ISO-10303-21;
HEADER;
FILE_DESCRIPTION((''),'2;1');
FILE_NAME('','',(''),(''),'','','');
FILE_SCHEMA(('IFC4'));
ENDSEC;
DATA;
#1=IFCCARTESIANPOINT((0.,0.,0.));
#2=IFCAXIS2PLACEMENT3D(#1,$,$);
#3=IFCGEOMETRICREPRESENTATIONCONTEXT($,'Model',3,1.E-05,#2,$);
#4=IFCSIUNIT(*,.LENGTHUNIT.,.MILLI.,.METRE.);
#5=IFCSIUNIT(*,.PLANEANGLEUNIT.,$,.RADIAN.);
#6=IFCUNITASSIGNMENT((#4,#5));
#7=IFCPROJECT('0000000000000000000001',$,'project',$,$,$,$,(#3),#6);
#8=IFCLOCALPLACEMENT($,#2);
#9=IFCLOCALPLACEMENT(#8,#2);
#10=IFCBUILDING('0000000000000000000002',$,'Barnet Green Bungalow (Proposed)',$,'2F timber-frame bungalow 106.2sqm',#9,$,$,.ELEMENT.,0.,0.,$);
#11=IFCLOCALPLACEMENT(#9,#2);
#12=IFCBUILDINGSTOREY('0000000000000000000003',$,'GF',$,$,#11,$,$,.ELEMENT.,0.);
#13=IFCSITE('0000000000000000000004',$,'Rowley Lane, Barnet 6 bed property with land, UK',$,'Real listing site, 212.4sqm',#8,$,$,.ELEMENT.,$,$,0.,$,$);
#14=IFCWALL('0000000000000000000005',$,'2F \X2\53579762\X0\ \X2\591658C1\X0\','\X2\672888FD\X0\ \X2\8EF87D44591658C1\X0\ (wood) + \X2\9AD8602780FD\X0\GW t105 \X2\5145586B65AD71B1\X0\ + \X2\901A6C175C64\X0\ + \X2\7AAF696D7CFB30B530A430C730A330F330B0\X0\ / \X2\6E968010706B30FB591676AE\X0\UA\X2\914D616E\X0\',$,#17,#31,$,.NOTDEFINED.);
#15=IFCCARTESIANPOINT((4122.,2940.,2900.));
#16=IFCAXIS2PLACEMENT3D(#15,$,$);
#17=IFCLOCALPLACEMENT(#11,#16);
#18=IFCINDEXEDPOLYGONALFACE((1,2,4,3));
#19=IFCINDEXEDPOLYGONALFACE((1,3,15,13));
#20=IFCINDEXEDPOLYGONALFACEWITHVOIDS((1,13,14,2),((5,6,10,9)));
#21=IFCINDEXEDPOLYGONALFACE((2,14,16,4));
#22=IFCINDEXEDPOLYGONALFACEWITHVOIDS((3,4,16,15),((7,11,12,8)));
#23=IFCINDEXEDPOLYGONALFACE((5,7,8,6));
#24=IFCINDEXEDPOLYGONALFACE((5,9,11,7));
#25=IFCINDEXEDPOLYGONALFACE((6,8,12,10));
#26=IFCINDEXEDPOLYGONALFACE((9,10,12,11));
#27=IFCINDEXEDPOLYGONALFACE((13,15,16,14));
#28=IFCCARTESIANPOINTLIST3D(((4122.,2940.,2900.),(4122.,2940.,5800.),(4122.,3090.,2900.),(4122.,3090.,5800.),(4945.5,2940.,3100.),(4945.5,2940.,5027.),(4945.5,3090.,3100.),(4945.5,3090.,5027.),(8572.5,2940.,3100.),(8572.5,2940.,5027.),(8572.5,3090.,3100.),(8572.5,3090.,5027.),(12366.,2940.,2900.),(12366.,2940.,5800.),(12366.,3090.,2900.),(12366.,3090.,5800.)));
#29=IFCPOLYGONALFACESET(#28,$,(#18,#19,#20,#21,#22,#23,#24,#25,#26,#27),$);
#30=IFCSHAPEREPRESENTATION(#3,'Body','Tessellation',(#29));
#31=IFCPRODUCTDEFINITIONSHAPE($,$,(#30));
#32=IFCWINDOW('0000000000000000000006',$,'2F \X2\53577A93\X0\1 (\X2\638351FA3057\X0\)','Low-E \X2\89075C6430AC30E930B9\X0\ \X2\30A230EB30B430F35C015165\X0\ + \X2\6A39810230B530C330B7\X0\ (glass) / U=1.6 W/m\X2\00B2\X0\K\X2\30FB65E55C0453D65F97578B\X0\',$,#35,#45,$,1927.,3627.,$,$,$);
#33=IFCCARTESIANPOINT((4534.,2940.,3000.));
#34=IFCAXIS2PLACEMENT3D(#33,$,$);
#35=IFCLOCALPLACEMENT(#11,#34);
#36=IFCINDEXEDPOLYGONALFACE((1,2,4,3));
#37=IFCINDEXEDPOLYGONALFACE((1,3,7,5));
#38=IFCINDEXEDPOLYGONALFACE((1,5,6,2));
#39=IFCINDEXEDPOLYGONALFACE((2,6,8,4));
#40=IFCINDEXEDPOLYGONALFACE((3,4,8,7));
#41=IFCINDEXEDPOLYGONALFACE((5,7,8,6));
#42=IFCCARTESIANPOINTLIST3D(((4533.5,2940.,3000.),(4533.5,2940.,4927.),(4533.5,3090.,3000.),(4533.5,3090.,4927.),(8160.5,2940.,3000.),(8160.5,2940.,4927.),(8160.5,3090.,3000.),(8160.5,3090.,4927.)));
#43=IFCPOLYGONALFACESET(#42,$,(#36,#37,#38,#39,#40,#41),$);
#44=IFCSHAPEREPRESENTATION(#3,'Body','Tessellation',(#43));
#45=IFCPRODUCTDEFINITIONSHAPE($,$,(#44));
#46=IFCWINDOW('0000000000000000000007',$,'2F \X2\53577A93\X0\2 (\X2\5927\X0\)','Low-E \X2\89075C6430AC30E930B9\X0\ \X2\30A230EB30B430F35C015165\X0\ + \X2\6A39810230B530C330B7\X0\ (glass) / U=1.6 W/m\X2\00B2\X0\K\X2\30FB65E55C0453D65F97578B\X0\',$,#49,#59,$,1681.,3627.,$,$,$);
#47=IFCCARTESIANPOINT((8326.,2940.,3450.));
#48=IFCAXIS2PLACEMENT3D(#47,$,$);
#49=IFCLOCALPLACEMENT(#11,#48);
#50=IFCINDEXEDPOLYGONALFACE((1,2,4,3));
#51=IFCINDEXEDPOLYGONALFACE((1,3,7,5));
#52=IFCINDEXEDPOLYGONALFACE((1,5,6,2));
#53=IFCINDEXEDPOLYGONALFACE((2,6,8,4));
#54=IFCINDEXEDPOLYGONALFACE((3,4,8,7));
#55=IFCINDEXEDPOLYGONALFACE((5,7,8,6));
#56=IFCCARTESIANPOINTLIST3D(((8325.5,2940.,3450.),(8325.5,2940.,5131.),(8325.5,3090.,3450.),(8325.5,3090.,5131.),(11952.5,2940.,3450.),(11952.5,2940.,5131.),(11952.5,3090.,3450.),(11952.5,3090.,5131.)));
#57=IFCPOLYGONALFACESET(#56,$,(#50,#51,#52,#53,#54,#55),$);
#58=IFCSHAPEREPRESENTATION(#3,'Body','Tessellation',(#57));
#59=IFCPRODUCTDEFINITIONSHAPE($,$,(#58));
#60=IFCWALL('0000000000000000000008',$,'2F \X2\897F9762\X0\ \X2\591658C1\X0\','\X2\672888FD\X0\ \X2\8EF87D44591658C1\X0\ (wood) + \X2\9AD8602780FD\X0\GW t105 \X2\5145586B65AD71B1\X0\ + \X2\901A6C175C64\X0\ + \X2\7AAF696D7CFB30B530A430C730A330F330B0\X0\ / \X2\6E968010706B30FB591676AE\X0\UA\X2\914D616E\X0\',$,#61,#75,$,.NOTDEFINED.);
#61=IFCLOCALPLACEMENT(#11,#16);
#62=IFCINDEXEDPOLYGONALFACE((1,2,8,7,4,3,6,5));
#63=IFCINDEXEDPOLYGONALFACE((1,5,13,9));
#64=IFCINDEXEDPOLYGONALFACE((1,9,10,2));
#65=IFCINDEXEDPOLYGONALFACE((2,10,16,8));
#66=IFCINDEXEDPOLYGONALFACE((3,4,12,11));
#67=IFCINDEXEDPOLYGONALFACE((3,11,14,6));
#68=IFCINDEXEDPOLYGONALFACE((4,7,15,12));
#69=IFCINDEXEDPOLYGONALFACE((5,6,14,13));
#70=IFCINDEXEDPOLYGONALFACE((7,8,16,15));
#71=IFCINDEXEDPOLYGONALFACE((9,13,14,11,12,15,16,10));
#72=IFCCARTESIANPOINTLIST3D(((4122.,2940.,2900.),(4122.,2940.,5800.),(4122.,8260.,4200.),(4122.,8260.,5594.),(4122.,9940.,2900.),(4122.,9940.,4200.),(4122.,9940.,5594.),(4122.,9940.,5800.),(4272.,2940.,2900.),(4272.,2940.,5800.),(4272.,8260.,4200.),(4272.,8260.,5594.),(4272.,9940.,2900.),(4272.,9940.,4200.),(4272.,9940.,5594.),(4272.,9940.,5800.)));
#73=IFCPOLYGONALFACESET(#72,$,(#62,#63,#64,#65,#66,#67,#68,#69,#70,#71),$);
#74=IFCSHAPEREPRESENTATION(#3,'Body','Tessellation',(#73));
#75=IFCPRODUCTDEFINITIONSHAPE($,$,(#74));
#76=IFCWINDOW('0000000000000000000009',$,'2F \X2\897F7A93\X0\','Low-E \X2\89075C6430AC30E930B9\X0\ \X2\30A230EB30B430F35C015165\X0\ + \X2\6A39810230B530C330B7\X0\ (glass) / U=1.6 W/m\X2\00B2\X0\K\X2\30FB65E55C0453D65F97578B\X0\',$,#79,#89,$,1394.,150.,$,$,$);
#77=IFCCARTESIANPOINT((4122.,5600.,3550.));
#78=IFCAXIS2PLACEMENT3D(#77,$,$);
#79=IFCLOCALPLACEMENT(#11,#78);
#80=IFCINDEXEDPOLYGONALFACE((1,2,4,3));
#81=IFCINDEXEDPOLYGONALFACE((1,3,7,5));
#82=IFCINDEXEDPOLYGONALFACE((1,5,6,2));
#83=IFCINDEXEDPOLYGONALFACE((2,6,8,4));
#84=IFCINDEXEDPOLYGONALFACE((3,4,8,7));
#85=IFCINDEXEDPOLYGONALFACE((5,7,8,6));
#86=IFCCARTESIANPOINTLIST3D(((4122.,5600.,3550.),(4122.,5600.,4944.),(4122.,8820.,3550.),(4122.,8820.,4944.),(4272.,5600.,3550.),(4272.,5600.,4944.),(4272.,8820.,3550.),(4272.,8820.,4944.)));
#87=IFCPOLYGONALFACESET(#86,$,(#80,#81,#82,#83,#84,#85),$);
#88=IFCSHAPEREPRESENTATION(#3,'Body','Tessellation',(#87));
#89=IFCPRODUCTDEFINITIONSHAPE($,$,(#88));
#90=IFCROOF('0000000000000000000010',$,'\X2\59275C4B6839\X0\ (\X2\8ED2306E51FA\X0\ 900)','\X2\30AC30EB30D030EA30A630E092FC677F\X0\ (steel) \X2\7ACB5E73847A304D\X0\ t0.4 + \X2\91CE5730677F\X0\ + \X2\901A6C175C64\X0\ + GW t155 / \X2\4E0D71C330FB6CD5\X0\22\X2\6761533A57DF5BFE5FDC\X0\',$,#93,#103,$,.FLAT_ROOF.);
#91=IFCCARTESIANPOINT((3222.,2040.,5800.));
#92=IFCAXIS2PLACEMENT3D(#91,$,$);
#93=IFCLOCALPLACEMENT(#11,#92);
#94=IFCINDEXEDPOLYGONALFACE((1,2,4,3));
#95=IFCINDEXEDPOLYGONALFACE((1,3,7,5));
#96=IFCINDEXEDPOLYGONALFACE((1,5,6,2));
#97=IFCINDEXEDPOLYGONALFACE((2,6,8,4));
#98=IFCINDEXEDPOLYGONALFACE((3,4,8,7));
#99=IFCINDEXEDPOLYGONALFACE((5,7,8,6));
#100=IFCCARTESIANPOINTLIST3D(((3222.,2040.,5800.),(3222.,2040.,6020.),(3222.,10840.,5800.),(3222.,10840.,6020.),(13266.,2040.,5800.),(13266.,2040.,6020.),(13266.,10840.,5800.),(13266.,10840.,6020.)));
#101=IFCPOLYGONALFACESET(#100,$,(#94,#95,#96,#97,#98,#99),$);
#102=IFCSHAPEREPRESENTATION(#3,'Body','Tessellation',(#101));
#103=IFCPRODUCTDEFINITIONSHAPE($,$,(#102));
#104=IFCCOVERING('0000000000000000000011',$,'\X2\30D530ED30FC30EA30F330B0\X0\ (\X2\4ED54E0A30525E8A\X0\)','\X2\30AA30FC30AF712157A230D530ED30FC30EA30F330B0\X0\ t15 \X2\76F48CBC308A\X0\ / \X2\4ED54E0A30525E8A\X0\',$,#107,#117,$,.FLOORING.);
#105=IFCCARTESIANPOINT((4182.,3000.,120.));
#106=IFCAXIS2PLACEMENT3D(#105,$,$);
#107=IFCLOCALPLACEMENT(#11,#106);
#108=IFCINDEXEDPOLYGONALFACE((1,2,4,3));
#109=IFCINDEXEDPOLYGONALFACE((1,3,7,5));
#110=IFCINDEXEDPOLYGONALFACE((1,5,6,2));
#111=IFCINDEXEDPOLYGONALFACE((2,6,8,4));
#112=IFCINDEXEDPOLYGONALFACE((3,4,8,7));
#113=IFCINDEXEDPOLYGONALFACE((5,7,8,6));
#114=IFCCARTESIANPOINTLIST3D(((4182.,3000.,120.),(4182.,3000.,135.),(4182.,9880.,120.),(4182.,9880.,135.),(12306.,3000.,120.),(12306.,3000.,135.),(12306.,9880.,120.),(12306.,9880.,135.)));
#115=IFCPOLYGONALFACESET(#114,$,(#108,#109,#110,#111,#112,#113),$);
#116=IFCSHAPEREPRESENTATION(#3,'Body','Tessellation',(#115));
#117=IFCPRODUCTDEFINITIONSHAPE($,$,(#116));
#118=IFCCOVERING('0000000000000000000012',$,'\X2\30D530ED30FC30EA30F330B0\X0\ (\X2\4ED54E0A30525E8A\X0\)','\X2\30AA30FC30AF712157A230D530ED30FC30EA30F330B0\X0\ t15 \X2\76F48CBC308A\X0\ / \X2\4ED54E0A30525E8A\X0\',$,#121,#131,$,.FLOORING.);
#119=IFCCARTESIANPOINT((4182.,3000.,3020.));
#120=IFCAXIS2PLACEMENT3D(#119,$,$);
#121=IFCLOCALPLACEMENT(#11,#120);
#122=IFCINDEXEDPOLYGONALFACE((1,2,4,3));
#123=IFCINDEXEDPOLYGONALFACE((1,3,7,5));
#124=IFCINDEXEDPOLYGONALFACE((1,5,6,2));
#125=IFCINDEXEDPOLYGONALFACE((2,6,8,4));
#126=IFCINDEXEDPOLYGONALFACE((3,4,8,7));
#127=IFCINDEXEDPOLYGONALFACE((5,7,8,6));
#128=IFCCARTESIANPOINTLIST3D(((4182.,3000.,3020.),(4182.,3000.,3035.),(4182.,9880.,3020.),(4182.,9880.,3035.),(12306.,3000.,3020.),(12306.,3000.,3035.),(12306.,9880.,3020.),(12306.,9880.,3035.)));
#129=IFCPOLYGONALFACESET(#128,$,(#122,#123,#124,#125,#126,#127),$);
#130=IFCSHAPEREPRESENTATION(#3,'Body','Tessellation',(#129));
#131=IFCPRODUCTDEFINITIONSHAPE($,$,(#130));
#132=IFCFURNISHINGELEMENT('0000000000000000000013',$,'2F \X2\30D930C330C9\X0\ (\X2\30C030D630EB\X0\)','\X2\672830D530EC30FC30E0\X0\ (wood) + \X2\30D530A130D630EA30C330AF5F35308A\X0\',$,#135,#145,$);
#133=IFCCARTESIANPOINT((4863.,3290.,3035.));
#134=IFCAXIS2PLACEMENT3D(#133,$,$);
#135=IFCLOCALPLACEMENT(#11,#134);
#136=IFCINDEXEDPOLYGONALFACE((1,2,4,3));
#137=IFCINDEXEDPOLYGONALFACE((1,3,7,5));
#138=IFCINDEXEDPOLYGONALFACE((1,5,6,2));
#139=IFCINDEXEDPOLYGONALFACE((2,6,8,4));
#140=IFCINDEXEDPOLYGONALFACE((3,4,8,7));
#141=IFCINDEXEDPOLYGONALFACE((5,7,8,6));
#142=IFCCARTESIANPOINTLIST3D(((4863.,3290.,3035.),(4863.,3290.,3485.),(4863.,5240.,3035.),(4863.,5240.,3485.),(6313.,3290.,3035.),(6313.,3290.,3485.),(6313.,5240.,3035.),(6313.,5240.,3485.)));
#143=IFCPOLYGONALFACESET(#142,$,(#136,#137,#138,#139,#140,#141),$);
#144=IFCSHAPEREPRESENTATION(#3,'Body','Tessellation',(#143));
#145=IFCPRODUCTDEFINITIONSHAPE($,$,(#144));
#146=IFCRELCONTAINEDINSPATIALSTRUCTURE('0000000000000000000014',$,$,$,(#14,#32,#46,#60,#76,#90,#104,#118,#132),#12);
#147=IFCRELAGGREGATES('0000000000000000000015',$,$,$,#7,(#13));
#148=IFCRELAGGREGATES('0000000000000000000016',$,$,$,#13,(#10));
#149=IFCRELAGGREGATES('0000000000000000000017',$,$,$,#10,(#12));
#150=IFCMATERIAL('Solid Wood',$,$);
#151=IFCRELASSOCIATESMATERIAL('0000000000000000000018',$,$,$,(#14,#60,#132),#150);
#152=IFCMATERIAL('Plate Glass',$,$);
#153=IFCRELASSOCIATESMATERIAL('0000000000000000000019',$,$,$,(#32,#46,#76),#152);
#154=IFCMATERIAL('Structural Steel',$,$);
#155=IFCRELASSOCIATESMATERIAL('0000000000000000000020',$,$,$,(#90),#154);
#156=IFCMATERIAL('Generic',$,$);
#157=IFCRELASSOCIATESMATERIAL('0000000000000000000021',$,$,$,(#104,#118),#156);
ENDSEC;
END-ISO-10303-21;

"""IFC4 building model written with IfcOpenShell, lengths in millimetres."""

from ifc_helpers import new_model, si_unit, frame, frame_2d, origin, place, context, project, spatial, rectangle, extrude, material, element, fill, save


model = new_model("IFC4")

# Units and contexts
model_context = context("Model", 3, precision=1e-05, world=origin())
ifc_project = project(units=[si_unit("LENGTHUNIT", "METRE", prefix="MILLI"), si_unit("PLANEANGLEUNIT", "RADIAN")], contexts=[model_context])

# Site, building, storey
site_placement = place(None, origin())
site = spatial("IfcSite", under=ifc_project, at=site_placement, Name="Rowley Lane, Barnet 6 bed property with land, UK", ObjectType="Real listing site, 212.4sqm", CompositionType="ELEMENT", RefElevation=0.0)
building_placement = place(site_placement, origin())
building = spatial("IfcBuilding", under=site, at=building_placement, Name="Barnet Green Bungalow (Proposed)", ObjectType="2F timber-frame bungalow 106.2sqm", CompositionType="ELEMENT", ElevationOfRefHeight=0.0, ElevationOfTerrain=0.0)
storey_placement = place(building_placement, origin())
storey = spatial("IfcBuildingStorey", under=building, at=storey_placement, Name="GF", CompositionType="ELEMENT", Elevation=0.0)

# Shared definitions
ifc_material_1 = material(Name="Solid Wood")

# Shared definitions
ifc_material_2 = material(Name="Plate Glass")

# Wall, openings, windows
wall_1_placement = place(storey_placement, frame((4122.0, 2940.0, 2900.0)))
wall_1 = element("IfcWall", 1, at=wall_1_placement, inside=storey, material=ifc_material_1, Name="2F 南面 外壁", Description="木製 軸組外壁 (wood) + 高性能GW t105 充填断熱 + 通気層 + 窯業系サイディング / 準耐火・外皮UA配慮", PredefinedType="NOTDEFINED", context=model_context, shape_type="SweptSolid", body=[
    extrude(rectangle(XDim=8244.0, YDim=150.0, at=frame_2d((4122.0, 75.0))), frame((4122.0, 2940.0, 2900.0)), (0.0, 0.0, 1.0), 2900.0),
])
opening_1_placement = place(storey_placement, frame((4534.0, 2940.0, 3000.0)))
opening_1 = element("IfcOpeningElement", 2, at=opening_1_placement, cuts=wall_1, PredefinedType="NOTDEFINED", context=model_context, shape_type="SweptSolid", body=[
    extrude(rectangle(XDim=3627.0, YDim=150.0, at=frame_2d((1813.0, 75.0))), frame((4534.0, 2940.0, 3000.0)), (0.0, 0.0, 1.0), 1927.0),
])
opening_2_placement = place(storey_placement, frame((8326.0, 2940.0, 3450.0)))
opening_2 = element("IfcOpeningElement", 3, at=opening_2_placement, cuts=wall_1, PredefinedType="NOTDEFINED", context=model_context, shape_type="SweptSolid", body=[
    extrude(rectangle(XDim=3627.0, YDim=150.0, at=frame_2d((1813.0, 75.0))), frame((8326.0, 2940.0, 3450.0)), (0.0, 0.0, 1.0), 1681.0),
])
window_1_placement = place(storey_placement, frame((4534.0, 2940.0, 3000.0)))
window_1 = element("IfcWindow", 4, at=window_1_placement, inside=storey, material=ifc_material_2, Name="2F 南窓1 (掃出し)", Description="Low-E 複層ガラス アルゴン封入 + 樹脂サッシ (glass) / U=1.6 W/m²K・日射取得型", OverallHeight=1927.0, OverallWidth=3627.0, context=model_context, shape_type="SweptSolid", body=[
    extrude(rectangle(XDim=3627.0, YDim=150.0, at=frame_2d((1813.0, 75.0))), frame((4534.0, 2940.0, 3000.0)), (0.0, 0.0, 1.0), 1927.0),
])
fill(opening_1, window_1)
window_2_placement = place(storey_placement, frame((8326.0, 2940.0, 3450.0)))
window_2 = element("IfcWindow", 5, at=window_2_placement, inside=storey, material=ifc_material_2, Name="2F 南窓2 (大)", Description="Low-E 複層ガラス アルゴン封入 + 樹脂サッシ (glass) / U=1.6 W/m²K・日射取得型", OverallHeight=1681.0, OverallWidth=3627.0, context=model_context, shape_type="SweptSolid", body=[
    extrude(rectangle(XDim=3627.0, YDim=150.0, at=frame_2d((1813.0, 75.0))), frame((8326.0, 2940.0, 3450.0)), (0.0, 0.0, 1.0), 1681.0),
])
fill(opening_2, window_2)

# Wall, opening, window
wall_2_placement = place(storey_placement, frame((4122.0, 2940.0, 2900.0)))
wall_2 = element("IfcWall", 6, at=wall_2_placement, inside=storey, material=ifc_material_1, Name="2F 西面 外壁", Description="木製 軸組外壁 (wood) + 高性能GW t105 充填断熱 + 通気層 + 窯業系サイディング / 準耐火・外皮UA配慮", PredefinedType="NOTDEFINED", context=model_context, shape_type="SweptSolid", body=[
    extrude(rectangle(XDim=150.0, YDim=7000.0, at=frame_2d((75.0, 3500.0))), frame((4122.0, 2940.0, 2900.0)), (0.0, 0.0, 1.0), 2900.0),
])
opening_3_placement = place(storey_placement, frame((4122.0, 5600.0, 3550.0)))
opening_3 = element("IfcOpeningElement", 7, at=opening_3_placement, cuts=wall_2, PredefinedType="NOTDEFINED", context=model_context, shape_type="SweptSolid", body=[
    extrude(rectangle(XDim=150.0, YDim=3220.0, at=frame_2d((75.0, 1610.0))), frame((4122.0, 5600.0, 3550.0)), (0.0, 0.0, 1.0), 1394.0),
])
window_3_placement = place(storey_placement, frame((4122.0, 5600.0, 3550.0)))
window_3 = element("IfcWindow", 8, at=window_3_placement, inside=storey, material=ifc_material_2, Name="2F 西窓", Description="Low-E 複層ガラス アルゴン封入 + 樹脂サッシ (glass) / U=1.6 W/m²K・日射取得型", OverallHeight=1394.0, OverallWidth=150.0, context=model_context, shape_type="SweptSolid", body=[
    extrude(rectangle(XDim=150.0, YDim=3220.0, at=frame_2d((75.0, 1610.0))), frame((4122.0, 5600.0, 3550.0)), (0.0, 0.0, 1.0), 1394.0),
])
fill(opening_3, window_3)

# Roof
ifc_material_3 = material(Name="Structural Steel")
roof_placement = place(storey_placement, frame((3222.0, 2040.0, 5800.0)))
element("IfcRoof", 9, at=roof_placement, inside=storey, material=ifc_material_3, Name="大屋根 (軒の出 900)", Description="ガルバリウム鋼板 (steel) 立平葺き t0.4 + 野地板 + 通気層 + GW t155 / 不燃・法22条区域対応", PredefinedType="FLAT_ROOF", context=model_context, shape_type="SweptSolid", body=[
    extrude(rectangle(XDim=10044.0, YDim=8800.0, at=frame_2d((5022.0, 4400.0))), frame((3222.0, 2040.0, 5800.0)), (0.0, 0.0, 1.0), 220.0),
])

# Coverings
ifc_material_4 = material(Name="Generic")
covering_1_placement = place(storey_placement, frame((4182.0, 3000.0, 120.0)))
element("IfcCovering", 10, at=covering_1_placement, inside=storey, material=ifc_material_4, Name="フローリング (仕上げ床)", Description="オーク無垢フローリング t15 直貼り / 仕上げ床", PredefinedType="FLOORING", context=model_context, shape_type="SweptSolid", body=[
    extrude(rectangle(XDim=8124.0, YDim=6880.0, at=frame_2d((4062.0, 3440.0))), frame((4182.0, 3000.0, 120.0)), (0.0, 0.0, 1.0), 15.0),
])
covering_2_placement = place(storey_placement, frame((4182.0, 3000.0, 3020.0)))
element("IfcCovering", 11, at=covering_2_placement, inside=storey, material=ifc_material_4, Name="フローリング (仕上げ床)", Description="オーク無垢フローリング t15 直貼り / 仕上げ床", PredefinedType="FLOORING", context=model_context, shape_type="SweptSolid", body=[
    extrude(rectangle(XDim=8124.0, YDim=6880.0, at=frame_2d((4062.0, 3440.0))), frame((4182.0, 3000.0, 3020.0)), (0.0, 0.0, 1.0), 15.0),
])

# Furnishing element
furnishing_placement = place(storey_placement, frame((4863.0, 3290.0, 3035.0)))
element("IfcFurnishingElement", 12, at=furnishing_placement, inside=storey, material=ifc_material_1, Name="2F ベッド (ダブル)", Description="木フレーム (wood) + ファブリック張り", context=model_context, shape_type="SweptSolid", body=[
    extrude(rectangle(XDim=1450.0, YDim=1950.0, at=frame_2d((725.0, 975.0))), frame((4863.0, 3290.0, 3035.0)), (0.0, 0.0, 1.0), 450.0),
])

save(model, "model.ifc")
